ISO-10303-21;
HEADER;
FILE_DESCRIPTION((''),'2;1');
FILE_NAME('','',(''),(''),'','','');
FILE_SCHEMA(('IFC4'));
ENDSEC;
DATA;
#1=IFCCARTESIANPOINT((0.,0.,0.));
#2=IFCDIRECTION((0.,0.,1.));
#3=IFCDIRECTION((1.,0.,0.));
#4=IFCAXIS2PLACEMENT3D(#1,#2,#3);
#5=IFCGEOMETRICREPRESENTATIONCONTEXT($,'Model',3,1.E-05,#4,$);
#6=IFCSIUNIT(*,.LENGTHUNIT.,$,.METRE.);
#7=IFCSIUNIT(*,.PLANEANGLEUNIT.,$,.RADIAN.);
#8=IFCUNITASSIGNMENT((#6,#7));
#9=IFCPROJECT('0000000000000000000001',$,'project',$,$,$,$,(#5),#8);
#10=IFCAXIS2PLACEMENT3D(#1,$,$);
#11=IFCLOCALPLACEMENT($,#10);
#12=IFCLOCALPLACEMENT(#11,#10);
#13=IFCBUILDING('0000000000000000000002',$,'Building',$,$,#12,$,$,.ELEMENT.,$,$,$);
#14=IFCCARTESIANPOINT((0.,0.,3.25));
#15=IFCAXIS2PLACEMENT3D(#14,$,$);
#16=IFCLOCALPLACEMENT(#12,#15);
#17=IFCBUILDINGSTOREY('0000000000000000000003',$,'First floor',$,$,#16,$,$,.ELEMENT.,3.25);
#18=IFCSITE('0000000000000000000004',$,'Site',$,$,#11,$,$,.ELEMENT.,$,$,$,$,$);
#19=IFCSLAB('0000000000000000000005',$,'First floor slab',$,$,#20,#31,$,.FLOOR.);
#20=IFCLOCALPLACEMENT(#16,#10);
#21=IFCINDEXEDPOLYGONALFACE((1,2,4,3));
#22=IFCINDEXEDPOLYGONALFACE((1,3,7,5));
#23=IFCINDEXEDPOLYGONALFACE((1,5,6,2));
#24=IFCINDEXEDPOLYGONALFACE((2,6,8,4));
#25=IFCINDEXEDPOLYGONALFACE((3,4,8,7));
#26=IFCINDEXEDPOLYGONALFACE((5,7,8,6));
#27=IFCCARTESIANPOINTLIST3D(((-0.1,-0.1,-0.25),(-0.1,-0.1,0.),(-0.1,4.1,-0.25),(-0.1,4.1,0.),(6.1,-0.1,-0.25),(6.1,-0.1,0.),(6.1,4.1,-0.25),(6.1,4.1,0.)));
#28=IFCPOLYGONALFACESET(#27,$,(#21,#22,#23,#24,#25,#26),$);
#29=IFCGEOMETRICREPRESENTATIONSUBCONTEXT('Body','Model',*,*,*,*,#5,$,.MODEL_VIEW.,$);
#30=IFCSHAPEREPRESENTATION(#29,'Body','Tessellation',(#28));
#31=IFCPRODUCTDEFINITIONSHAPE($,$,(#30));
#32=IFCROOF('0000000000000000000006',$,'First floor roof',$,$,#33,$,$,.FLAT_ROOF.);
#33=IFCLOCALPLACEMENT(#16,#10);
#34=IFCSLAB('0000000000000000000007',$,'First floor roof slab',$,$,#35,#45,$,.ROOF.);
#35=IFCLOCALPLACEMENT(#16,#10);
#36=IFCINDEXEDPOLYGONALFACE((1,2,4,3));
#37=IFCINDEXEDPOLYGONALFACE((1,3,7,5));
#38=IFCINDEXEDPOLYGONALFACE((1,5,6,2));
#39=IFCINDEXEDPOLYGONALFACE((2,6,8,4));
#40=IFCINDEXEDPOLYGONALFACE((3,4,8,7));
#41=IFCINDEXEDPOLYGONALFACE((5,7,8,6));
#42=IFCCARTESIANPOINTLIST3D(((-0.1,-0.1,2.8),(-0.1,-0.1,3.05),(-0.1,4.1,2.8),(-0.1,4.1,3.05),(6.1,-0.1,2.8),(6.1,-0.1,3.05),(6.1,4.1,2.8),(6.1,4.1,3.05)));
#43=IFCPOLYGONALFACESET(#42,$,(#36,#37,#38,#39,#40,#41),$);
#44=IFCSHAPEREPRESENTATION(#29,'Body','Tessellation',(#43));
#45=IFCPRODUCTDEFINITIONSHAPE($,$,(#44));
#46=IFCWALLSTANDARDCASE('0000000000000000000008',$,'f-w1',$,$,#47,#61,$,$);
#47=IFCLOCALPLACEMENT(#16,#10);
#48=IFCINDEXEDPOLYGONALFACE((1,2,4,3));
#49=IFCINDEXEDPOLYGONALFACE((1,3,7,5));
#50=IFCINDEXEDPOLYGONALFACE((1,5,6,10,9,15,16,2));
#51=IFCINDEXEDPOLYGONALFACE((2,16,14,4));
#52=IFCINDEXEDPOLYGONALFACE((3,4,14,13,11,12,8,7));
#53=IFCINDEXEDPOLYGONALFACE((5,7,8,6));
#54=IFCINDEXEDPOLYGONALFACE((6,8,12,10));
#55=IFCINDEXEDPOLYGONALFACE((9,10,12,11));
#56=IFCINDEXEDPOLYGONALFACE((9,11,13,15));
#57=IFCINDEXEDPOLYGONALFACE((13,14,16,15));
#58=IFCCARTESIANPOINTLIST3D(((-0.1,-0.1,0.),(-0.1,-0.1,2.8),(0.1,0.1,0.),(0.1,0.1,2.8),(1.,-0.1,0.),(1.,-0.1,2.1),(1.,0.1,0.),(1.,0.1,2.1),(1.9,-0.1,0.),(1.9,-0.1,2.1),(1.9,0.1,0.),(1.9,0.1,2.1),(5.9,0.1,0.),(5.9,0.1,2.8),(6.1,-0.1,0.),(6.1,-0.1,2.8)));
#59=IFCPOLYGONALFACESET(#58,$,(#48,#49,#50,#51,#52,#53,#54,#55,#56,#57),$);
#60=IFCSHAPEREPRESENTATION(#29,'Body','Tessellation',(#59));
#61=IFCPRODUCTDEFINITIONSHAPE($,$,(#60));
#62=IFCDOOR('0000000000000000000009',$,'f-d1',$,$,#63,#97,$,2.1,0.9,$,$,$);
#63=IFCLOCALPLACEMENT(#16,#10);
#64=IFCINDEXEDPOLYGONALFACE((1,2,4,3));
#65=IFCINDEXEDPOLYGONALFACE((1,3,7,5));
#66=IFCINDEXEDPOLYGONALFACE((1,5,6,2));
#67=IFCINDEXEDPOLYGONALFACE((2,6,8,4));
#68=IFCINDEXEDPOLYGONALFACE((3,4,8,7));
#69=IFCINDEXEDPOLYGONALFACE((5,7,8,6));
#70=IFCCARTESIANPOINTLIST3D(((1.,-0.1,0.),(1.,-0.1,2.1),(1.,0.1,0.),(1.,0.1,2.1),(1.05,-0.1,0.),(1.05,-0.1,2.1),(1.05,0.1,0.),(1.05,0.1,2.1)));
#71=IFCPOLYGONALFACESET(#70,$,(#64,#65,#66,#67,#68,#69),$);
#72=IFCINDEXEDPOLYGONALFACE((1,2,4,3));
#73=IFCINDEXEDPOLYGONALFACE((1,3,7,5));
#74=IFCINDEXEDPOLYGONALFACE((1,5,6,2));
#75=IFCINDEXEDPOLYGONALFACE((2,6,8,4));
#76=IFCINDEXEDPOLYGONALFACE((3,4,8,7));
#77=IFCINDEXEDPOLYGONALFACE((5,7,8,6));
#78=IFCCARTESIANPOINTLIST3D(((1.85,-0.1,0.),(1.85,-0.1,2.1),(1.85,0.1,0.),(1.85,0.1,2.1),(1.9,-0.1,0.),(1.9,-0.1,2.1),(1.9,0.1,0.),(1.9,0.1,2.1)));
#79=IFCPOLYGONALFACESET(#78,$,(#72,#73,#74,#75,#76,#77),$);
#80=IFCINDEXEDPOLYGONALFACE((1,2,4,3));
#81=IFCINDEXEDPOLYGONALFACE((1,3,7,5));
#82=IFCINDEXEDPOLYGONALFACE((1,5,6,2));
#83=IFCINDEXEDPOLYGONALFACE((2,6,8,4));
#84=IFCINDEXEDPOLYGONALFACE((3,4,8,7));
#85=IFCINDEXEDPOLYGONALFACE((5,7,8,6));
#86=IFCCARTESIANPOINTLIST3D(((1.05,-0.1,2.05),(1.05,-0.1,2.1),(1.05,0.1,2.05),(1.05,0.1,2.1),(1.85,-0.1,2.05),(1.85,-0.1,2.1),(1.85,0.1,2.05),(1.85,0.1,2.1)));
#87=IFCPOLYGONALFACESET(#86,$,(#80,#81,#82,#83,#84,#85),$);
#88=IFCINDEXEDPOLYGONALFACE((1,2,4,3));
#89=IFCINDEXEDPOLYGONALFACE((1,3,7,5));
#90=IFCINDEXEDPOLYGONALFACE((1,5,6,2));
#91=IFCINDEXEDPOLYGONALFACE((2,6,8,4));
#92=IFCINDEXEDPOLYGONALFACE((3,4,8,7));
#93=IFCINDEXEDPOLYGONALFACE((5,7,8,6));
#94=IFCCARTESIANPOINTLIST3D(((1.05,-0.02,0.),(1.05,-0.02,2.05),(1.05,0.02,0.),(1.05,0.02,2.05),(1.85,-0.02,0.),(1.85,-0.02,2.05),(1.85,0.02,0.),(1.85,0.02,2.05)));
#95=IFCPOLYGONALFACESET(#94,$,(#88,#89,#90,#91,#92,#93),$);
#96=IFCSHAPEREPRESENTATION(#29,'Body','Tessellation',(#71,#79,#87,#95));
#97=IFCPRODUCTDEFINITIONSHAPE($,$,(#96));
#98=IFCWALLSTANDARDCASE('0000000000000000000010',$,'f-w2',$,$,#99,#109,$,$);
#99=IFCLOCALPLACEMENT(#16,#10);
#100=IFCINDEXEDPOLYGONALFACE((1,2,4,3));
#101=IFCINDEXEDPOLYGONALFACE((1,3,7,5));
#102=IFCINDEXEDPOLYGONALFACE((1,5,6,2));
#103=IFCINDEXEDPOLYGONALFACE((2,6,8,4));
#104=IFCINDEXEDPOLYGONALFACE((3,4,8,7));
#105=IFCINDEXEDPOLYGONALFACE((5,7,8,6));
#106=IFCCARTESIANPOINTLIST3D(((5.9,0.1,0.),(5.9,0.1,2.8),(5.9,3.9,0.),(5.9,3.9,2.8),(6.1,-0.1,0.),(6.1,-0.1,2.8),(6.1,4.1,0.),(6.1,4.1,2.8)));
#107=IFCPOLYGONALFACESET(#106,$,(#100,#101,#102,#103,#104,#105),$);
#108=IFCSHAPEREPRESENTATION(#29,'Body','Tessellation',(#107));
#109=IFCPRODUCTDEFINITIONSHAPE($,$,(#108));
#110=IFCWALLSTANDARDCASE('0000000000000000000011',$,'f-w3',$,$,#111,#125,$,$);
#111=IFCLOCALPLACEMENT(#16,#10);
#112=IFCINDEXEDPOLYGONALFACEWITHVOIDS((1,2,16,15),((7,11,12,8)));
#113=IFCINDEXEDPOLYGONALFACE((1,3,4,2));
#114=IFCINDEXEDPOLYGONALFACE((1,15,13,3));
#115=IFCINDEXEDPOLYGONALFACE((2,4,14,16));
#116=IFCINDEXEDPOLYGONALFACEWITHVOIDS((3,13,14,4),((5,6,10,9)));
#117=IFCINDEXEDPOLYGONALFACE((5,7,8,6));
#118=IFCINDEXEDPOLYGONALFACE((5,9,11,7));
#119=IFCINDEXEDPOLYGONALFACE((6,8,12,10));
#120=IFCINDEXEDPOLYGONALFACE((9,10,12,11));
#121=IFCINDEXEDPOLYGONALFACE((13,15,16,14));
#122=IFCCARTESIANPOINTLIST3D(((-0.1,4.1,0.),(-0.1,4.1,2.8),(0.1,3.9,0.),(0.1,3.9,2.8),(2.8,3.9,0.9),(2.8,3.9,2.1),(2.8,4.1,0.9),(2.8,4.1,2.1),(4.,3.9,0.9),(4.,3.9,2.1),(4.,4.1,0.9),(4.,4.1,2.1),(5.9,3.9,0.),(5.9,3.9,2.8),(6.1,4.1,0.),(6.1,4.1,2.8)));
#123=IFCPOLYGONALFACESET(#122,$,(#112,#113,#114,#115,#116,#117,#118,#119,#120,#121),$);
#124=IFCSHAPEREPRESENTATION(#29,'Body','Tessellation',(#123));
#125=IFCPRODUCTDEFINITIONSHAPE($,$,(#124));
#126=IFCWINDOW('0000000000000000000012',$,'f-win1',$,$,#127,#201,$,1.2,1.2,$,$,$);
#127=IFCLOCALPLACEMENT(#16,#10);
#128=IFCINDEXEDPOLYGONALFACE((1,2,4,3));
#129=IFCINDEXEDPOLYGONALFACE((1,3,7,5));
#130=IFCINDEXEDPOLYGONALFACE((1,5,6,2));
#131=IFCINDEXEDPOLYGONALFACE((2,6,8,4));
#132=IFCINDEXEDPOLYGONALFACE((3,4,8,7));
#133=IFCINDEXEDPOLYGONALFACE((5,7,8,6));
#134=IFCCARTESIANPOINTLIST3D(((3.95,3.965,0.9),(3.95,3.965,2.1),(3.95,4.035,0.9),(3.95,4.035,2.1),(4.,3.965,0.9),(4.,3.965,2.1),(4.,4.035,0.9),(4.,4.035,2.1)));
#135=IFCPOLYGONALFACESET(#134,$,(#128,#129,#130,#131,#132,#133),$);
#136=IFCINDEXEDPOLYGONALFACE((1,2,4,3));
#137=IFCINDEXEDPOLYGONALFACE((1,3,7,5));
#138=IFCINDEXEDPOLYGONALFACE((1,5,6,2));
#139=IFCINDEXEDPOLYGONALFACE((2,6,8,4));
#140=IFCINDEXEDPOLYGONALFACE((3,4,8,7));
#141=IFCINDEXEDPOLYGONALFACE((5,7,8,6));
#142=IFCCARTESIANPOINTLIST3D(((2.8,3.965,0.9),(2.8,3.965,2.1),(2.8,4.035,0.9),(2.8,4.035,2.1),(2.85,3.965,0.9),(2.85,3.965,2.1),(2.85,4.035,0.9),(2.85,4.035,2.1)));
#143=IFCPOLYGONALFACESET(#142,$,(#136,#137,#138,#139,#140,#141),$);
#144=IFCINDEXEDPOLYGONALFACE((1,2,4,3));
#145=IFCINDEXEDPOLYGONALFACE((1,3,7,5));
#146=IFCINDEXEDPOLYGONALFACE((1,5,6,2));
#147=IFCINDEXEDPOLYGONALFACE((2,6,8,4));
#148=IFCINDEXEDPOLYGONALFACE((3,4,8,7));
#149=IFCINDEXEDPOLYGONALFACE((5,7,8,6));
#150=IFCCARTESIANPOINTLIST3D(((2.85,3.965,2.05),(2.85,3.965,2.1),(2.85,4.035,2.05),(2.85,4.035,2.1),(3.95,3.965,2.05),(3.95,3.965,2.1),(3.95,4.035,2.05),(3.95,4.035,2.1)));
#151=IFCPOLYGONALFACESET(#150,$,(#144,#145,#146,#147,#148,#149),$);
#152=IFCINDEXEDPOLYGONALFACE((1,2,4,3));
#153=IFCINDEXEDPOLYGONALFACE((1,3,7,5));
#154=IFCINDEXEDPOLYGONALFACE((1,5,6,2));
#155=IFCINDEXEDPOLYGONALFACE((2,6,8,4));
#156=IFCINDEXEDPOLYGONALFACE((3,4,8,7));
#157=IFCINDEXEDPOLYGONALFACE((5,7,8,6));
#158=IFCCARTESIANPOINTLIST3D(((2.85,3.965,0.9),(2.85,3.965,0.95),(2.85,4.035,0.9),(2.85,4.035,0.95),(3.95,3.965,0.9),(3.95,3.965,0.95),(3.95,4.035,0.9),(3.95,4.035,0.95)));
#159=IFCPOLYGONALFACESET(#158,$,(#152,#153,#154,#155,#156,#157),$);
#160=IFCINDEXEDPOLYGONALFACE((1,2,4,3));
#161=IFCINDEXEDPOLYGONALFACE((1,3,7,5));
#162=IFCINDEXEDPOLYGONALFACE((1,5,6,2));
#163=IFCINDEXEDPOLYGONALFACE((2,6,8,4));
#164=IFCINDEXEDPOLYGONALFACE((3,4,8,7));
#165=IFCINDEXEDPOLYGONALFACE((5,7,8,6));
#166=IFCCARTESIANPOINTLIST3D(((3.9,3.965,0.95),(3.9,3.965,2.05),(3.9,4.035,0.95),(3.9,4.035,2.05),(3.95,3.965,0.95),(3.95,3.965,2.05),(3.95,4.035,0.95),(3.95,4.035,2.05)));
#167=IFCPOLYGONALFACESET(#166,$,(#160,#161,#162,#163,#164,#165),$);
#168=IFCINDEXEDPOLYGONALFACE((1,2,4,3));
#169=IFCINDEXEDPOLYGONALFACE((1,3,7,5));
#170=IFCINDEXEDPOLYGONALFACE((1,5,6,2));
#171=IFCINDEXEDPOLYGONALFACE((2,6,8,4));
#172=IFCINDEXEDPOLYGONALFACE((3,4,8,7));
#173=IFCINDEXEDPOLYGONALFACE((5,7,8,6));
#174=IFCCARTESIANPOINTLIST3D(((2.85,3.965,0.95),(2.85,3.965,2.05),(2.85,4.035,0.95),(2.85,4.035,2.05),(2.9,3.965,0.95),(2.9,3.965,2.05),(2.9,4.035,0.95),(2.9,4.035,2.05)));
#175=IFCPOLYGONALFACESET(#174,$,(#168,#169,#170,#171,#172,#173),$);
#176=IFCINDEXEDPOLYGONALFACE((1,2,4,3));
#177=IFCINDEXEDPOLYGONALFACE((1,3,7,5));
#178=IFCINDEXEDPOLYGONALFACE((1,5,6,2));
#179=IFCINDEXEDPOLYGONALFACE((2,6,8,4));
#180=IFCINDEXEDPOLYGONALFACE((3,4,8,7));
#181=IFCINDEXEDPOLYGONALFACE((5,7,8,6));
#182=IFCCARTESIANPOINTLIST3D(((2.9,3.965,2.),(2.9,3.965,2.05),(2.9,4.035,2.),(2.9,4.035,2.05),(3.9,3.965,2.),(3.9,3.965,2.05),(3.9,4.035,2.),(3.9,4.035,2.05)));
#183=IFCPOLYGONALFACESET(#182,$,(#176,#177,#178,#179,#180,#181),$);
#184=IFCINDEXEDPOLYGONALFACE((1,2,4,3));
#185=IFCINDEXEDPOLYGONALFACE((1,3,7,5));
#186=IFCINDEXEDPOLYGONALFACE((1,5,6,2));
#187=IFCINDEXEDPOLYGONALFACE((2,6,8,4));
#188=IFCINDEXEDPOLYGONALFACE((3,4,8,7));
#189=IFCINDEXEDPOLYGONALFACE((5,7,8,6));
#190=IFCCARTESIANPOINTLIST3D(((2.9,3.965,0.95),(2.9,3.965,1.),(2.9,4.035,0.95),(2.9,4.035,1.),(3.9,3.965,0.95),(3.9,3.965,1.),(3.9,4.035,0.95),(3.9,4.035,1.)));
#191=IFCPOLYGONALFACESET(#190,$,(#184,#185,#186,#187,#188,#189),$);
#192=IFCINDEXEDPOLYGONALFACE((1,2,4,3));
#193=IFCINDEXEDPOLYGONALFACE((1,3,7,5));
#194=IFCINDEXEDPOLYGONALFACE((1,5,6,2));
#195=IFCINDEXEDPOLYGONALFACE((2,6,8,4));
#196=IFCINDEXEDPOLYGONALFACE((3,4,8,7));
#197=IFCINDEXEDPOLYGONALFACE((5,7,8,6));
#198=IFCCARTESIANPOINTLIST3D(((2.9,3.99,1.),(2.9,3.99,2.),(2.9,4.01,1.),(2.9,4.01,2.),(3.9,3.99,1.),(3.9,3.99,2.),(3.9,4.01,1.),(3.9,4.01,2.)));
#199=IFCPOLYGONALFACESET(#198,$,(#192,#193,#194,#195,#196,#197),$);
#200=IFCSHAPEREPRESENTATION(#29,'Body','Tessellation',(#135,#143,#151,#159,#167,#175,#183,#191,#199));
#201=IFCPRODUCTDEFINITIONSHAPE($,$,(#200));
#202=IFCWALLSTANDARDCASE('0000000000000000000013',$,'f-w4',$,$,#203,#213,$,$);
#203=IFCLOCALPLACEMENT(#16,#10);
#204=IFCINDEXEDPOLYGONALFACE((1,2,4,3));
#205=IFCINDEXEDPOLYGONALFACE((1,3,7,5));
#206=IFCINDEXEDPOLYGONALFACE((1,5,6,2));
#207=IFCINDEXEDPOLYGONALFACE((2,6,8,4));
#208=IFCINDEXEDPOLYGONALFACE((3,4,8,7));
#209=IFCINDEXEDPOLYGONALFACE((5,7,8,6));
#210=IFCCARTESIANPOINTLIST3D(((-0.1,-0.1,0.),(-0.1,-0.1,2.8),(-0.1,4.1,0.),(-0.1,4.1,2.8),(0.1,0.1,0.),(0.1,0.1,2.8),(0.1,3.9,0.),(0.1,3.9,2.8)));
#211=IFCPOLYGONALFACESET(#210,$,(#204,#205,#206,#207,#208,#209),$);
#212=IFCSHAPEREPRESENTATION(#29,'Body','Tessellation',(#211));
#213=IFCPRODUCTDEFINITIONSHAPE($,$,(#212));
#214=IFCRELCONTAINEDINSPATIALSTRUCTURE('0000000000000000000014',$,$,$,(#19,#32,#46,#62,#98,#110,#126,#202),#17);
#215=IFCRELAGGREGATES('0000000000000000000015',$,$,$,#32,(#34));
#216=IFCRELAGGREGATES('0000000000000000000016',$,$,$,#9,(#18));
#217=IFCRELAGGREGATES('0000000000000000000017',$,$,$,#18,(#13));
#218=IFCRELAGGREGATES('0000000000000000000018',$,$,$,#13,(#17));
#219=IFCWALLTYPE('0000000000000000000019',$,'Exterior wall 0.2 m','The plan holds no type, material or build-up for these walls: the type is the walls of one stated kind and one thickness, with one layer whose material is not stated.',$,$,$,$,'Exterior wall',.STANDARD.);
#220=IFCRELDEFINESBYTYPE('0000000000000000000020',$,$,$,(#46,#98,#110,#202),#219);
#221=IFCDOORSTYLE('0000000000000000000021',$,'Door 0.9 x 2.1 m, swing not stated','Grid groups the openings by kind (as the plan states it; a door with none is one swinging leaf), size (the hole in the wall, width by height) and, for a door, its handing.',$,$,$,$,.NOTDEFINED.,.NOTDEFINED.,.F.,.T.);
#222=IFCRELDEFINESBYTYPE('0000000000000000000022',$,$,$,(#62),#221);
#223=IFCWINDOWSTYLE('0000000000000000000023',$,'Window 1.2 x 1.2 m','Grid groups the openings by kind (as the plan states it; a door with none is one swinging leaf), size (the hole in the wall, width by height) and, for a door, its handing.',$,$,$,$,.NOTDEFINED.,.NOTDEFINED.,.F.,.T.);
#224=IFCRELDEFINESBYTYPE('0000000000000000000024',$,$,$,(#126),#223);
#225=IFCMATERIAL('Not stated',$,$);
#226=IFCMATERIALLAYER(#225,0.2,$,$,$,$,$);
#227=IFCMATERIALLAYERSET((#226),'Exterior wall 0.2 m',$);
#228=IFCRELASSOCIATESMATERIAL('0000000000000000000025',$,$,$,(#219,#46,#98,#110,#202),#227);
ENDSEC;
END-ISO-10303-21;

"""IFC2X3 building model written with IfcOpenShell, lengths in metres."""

from ifc_helpers import new_model, si_unit, frame, frame_2d, origin, origin_with_axes, place, context, subcontext, project, spatial, polyline, rectangle, outline, extrude, material, layer, layer_set, layer_usage, type_object, element, fill, aggregate, save


model = new_model("IFC2X3")

# Units and contexts
model_context = context("Model", 3, precision=1e-05, world=origin_with_axes())
body_context = subcontext(model_context, "Body", "Model", "MODEL_VIEW")
ifc_project = project(units=[si_unit("LENGTHUNIT", "METRE"), si_unit("PLANEANGLEUNIT", "RADIAN")], contexts=[model_context])

# Site, building, storey
site_placement = place(None, origin())
site = spatial("IfcSite", under=ifc_project, at=site_placement, Name="Site", CompositionType="ELEMENT")
building_placement = place(site_placement, origin())
building = spatial("IfcBuilding", under=site, at=building_placement, Name="Building", CompositionType="ELEMENT")
storey_placement = place(building_placement, frame((0.0, 0.0, 3.25)))
storey = spatial("IfcBuildingStorey", under=building, at=storey_placement, Name="First floor", CompositionType="ELEMENT", Elevation=3.25)

# Slab
slab_1_placement = place(storey_placement, frame((0.0, 0.0, -0.25)))
element("IfcSlab", 1, at=slab_1_placement, inside=storey, Name="First floor slab", PredefinedType="FLOOR", context=body_context, shape_type="SweptSolid", body=[
    extrude(outline(polyline([(-0.1, -0.1), (6.1, -0.1), (6.1, 4.1), (-0.1, 4.1), (-0.1, -0.1)])), origin(), (0.0, 0.0, 1.0), 0.25),
])

# Roof, slab
roof_placement = place(storey_placement, origin())
roof = element("IfcRoof", 2, at=roof_placement, inside=storey, Name="First floor roof", ShapeType="FLAT_ROOF")
slab_2_placement = place(storey_placement, frame((0.0, 0.0, 2.8)))
slab_2 = element("IfcSlab", 3, at=slab_2_placement, Name="First floor roof slab", PredefinedType="ROOF", context=body_context, shape_type="SweptSolid", body=[
    extrude(outline(polyline([(-0.1, -0.1), (6.1, -0.1), (6.1, 4.1), (-0.1, 4.1), (-0.1, -0.1)])), origin(), (0.0, 0.0, 1.0), 0.25),
])
aggregate(roof, [slab_2])

# Wall, opening, door
ifc_material = material(Name="Not stated")
ifc_layer = layer(ifc_material, 0.2)
ifc_layer_set = layer_set([ifc_layer], Name="Exterior wall 0.2 m")
ifc_layer_usage = layer_usage(ifc_layer_set, "AXIS2", "POSITIVE", -0.1)
wall_type = type_object("IfcWallType", Name="Exterior wall 0.2 m", Description="The plan holds no type, material or build-up for these walls: the type is the walls of one stated kind and one thickness, with one layer whose material is not stated.", ElementType="Exterior wall", PredefinedType="STANDARD", material=ifc_layer_set)
wall_1_placement = place(storey_placement, origin_with_axes())
wall_1 = element("IfcWallStandardCase", 4, at=wall_1_placement, inside=storey, type_object=wall_type, material=ifc_layer_usage, Name="f-w1", context=body_context, shape_type="SweptSolid", body=[
    extrude(outline(polyline([(-0.1, -0.1), (6.1, -0.1), (5.9, 0.1), (0.1, 0.1), (-0.1, -0.1)])), origin(), (0.0, 0.0, 1.0), 2.8),
])
opening_1_placement = place(wall_1_placement, frame((1.0, 0.0, 0.0)))
opening_1 = element("IfcOpeningElement", 5, at=opening_1_placement, cuts=wall_1, context=body_context, shape_type="SweptSolid", body=[
    extrude(rectangle(XDim=0.9, YDim=0.22, at=frame_2d((0.45, 0.0), x_axis=(1.0, 0.0))), origin(), (0.0, 0.0, 1.0), 2.1),
])
door_style = type_object("IfcDoorStyle", Name="Door 0.9 x 2.1 m, swing not stated", Description="Grid groups the openings by kind (as the plan states it; a door with none is one swinging leaf), size (the hole in the wall, width by height) and, for a door, its handing.", ConstructionType="NOTDEFINED", OperationType="NOTDEFINED", ParameterTakesPrecedence=False, Sizeable=True)
door_placement = place(opening_1_placement, origin())
door = element("IfcDoor", 6, at=door_placement, inside=storey, type_object=door_style, Name="f-d1", OverallHeight=2.1, OverallWidth=0.9, context=body_context, shape_type="SweptSolid", body=[
    extrude(rectangle(XDim=0.05, YDim=0.2, at=frame_2d((0.025, 0.0), x_axis=(1.0, 0.0))), origin(), (0.0, 0.0, 1.0), 2.1),
    extrude(rectangle(XDim=0.05, YDim=0.2, at=frame_2d((0.875, 0.0), x_axis=(1.0, 0.0))), origin(), (0.0, 0.0, 1.0), 2.1),
    extrude(rectangle(XDim=0.8, YDim=0.2, at=frame_2d((0.45, 0.0), x_axis=(1.0, 0.0))), frame((0.0, 0.0, 2.05)), (0.0, 0.0, 1.0), 0.05),
    extrude(rectangle(XDim=0.8, YDim=0.04, at=frame_2d((0.45, 0.0), x_axis=(1.0, 0.0))), origin(), (0.0, 0.0, 1.0), 2.05),
])
fill(opening_1, door)

# Wall
wall_2_placement = place(storey_placement, frame((6.0, 0.0, 0.0), z_axis=(0.0, 0.0, 1.0), x_axis=(0.0, 1.0, 0.0)))
element("IfcWallStandardCase", 7, at=wall_2_placement, inside=storey, type_object=wall_type, material=ifc_layer_usage, Name="f-w2", context=body_context, shape_type="SweptSolid", body=[
    extrude(outline(polyline([(-0.1, -0.1), (4.1, -0.1), (3.9, 0.1), (0.1, 0.1), (-0.1, -0.1)])), origin(), (0.0, 0.0, 1.0), 2.8),
])

# Wall, opening, window
wall_3_placement = place(storey_placement, frame((6.0, 4.0, 0.0), z_axis=(0.0, 0.0, 1.0), x_axis=(-1.0, 0.0, 0.0)))
wall_3 = element("IfcWallStandardCase", 8, at=wall_3_placement, inside=storey, type_object=wall_type, material=ifc_layer_usage, Name="f-w3", context=body_context, shape_type="SweptSolid", body=[
    extrude(outline(polyline([(-0.1, -0.1), (6.1, -0.1), (5.9, 0.1), (0.1, 0.1), (-0.1, -0.1)])), origin(), (0.0, 0.0, 1.0), 2.8),
])
opening_2_placement = place(wall_3_placement, frame((2.0, 0.0, 0.9)))
opening_2 = element("IfcOpeningElement", 9, at=opening_2_placement, cuts=wall_3, context=body_context, shape_type="SweptSolid", body=[
    extrude(rectangle(XDim=1.2, YDim=0.22, at=frame_2d((0.6, 0.0), x_axis=(1.0, 0.0))), origin(), (0.0, 0.0, 1.0), 1.2),
])
window_style = type_object("IfcWindowStyle", Name="Window 1.2 x 1.2 m", Description="Grid groups the openings by kind (as the plan states it; a door with none is one swinging leaf), size (the hole in the wall, width by height) and, for a door, its handing.", ConstructionType="NOTDEFINED", OperationType="NOTDEFINED", ParameterTakesPrecedence=False, Sizeable=True)
window_placement = place(opening_2_placement, origin())
window = element("IfcWindow", 10, at=window_placement, inside=storey, type_object=window_style, Name="f-win1", OverallHeight=1.2, OverallWidth=1.2, context=body_context, shape_type="SweptSolid", body=[
    extrude(rectangle(XDim=0.05, YDim=0.07, at=frame_2d((0.025, 0.0), x_axis=(1.0, 0.0))), origin(), (0.0, 0.0, 1.0), 1.2),
    extrude(rectangle(XDim=0.05, YDim=0.07, at=frame_2d((1.175, 0.0), x_axis=(1.0, 0.0))), origin(), (0.0, 0.0, 1.0), 1.2),
    extrude(rectangle(XDim=1.1, YDim=0.07, at=frame_2d((0.6, 0.0), x_axis=(1.0, 0.0))), frame((0.0, 0.0, 1.15)), (0.0, 0.0, 1.0), 0.05),
    extrude(rectangle(XDim=1.1, YDim=0.07, at=frame_2d((0.6, 0.0), x_axis=(1.0, 0.0))), origin(), (0.0, 0.0, 1.0), 0.05),
    extrude(rectangle(XDim=0.05, YDim=0.07, at=frame_2d((0.075, 0.0), x_axis=(1.0, 0.0))), frame((0.0, 0.0, 0.05)), (0.0, 0.0, 1.0), 1.1),
    extrude(rectangle(XDim=0.05, YDim=0.07, at=frame_2d((1.125, 0.0), x_axis=(1.0, 0.0))), frame((0.0, 0.0, 0.05)), (0.0, 0.0, 1.0), 1.1),
    extrude(rectangle(XDim=1.0, YDim=0.07, at=frame_2d((0.6, 0.0), x_axis=(1.0, 0.0))), frame((0.0, 0.0, 1.1)), (0.0, 0.0, 1.0), 0.05),
    extrude(rectangle(XDim=1.0, YDim=0.07, at=frame_2d((0.6, 0.0), x_axis=(1.0, 0.0))), frame((0.0, 0.0, 0.05)), (0.0, 0.0, 1.0), 0.05),
    extrude(rectangle(XDim=1.0, YDim=0.02, at=frame_2d((0.6, 0.0), x_axis=(1.0, 0.0))), frame((0.0, 0.0, 0.1)), (0.0, 0.0, 1.0), 1.0),
])
fill(opening_2, window)

# Wall
wall_4_placement = place(storey_placement, frame((0.0, 4.0, 0.0), z_axis=(0.0, 0.0, 1.0), x_axis=(0.0, -1.0, 0.0)))
element("IfcWallStandardCase", 11, at=wall_4_placement, inside=storey, type_object=wall_type, material=ifc_layer_usage, Name="f-w4", context=body_context, shape_type="SweptSolid", body=[
    extrude(outline(polyline([(-0.1, -0.1), (4.1, -0.1), (3.9, 0.1), (0.1, 0.1), (-0.1, -0.1)])), origin(), (0.0, 0.0, 1.0), 2.8),
])

save(model, "model.ifc")
